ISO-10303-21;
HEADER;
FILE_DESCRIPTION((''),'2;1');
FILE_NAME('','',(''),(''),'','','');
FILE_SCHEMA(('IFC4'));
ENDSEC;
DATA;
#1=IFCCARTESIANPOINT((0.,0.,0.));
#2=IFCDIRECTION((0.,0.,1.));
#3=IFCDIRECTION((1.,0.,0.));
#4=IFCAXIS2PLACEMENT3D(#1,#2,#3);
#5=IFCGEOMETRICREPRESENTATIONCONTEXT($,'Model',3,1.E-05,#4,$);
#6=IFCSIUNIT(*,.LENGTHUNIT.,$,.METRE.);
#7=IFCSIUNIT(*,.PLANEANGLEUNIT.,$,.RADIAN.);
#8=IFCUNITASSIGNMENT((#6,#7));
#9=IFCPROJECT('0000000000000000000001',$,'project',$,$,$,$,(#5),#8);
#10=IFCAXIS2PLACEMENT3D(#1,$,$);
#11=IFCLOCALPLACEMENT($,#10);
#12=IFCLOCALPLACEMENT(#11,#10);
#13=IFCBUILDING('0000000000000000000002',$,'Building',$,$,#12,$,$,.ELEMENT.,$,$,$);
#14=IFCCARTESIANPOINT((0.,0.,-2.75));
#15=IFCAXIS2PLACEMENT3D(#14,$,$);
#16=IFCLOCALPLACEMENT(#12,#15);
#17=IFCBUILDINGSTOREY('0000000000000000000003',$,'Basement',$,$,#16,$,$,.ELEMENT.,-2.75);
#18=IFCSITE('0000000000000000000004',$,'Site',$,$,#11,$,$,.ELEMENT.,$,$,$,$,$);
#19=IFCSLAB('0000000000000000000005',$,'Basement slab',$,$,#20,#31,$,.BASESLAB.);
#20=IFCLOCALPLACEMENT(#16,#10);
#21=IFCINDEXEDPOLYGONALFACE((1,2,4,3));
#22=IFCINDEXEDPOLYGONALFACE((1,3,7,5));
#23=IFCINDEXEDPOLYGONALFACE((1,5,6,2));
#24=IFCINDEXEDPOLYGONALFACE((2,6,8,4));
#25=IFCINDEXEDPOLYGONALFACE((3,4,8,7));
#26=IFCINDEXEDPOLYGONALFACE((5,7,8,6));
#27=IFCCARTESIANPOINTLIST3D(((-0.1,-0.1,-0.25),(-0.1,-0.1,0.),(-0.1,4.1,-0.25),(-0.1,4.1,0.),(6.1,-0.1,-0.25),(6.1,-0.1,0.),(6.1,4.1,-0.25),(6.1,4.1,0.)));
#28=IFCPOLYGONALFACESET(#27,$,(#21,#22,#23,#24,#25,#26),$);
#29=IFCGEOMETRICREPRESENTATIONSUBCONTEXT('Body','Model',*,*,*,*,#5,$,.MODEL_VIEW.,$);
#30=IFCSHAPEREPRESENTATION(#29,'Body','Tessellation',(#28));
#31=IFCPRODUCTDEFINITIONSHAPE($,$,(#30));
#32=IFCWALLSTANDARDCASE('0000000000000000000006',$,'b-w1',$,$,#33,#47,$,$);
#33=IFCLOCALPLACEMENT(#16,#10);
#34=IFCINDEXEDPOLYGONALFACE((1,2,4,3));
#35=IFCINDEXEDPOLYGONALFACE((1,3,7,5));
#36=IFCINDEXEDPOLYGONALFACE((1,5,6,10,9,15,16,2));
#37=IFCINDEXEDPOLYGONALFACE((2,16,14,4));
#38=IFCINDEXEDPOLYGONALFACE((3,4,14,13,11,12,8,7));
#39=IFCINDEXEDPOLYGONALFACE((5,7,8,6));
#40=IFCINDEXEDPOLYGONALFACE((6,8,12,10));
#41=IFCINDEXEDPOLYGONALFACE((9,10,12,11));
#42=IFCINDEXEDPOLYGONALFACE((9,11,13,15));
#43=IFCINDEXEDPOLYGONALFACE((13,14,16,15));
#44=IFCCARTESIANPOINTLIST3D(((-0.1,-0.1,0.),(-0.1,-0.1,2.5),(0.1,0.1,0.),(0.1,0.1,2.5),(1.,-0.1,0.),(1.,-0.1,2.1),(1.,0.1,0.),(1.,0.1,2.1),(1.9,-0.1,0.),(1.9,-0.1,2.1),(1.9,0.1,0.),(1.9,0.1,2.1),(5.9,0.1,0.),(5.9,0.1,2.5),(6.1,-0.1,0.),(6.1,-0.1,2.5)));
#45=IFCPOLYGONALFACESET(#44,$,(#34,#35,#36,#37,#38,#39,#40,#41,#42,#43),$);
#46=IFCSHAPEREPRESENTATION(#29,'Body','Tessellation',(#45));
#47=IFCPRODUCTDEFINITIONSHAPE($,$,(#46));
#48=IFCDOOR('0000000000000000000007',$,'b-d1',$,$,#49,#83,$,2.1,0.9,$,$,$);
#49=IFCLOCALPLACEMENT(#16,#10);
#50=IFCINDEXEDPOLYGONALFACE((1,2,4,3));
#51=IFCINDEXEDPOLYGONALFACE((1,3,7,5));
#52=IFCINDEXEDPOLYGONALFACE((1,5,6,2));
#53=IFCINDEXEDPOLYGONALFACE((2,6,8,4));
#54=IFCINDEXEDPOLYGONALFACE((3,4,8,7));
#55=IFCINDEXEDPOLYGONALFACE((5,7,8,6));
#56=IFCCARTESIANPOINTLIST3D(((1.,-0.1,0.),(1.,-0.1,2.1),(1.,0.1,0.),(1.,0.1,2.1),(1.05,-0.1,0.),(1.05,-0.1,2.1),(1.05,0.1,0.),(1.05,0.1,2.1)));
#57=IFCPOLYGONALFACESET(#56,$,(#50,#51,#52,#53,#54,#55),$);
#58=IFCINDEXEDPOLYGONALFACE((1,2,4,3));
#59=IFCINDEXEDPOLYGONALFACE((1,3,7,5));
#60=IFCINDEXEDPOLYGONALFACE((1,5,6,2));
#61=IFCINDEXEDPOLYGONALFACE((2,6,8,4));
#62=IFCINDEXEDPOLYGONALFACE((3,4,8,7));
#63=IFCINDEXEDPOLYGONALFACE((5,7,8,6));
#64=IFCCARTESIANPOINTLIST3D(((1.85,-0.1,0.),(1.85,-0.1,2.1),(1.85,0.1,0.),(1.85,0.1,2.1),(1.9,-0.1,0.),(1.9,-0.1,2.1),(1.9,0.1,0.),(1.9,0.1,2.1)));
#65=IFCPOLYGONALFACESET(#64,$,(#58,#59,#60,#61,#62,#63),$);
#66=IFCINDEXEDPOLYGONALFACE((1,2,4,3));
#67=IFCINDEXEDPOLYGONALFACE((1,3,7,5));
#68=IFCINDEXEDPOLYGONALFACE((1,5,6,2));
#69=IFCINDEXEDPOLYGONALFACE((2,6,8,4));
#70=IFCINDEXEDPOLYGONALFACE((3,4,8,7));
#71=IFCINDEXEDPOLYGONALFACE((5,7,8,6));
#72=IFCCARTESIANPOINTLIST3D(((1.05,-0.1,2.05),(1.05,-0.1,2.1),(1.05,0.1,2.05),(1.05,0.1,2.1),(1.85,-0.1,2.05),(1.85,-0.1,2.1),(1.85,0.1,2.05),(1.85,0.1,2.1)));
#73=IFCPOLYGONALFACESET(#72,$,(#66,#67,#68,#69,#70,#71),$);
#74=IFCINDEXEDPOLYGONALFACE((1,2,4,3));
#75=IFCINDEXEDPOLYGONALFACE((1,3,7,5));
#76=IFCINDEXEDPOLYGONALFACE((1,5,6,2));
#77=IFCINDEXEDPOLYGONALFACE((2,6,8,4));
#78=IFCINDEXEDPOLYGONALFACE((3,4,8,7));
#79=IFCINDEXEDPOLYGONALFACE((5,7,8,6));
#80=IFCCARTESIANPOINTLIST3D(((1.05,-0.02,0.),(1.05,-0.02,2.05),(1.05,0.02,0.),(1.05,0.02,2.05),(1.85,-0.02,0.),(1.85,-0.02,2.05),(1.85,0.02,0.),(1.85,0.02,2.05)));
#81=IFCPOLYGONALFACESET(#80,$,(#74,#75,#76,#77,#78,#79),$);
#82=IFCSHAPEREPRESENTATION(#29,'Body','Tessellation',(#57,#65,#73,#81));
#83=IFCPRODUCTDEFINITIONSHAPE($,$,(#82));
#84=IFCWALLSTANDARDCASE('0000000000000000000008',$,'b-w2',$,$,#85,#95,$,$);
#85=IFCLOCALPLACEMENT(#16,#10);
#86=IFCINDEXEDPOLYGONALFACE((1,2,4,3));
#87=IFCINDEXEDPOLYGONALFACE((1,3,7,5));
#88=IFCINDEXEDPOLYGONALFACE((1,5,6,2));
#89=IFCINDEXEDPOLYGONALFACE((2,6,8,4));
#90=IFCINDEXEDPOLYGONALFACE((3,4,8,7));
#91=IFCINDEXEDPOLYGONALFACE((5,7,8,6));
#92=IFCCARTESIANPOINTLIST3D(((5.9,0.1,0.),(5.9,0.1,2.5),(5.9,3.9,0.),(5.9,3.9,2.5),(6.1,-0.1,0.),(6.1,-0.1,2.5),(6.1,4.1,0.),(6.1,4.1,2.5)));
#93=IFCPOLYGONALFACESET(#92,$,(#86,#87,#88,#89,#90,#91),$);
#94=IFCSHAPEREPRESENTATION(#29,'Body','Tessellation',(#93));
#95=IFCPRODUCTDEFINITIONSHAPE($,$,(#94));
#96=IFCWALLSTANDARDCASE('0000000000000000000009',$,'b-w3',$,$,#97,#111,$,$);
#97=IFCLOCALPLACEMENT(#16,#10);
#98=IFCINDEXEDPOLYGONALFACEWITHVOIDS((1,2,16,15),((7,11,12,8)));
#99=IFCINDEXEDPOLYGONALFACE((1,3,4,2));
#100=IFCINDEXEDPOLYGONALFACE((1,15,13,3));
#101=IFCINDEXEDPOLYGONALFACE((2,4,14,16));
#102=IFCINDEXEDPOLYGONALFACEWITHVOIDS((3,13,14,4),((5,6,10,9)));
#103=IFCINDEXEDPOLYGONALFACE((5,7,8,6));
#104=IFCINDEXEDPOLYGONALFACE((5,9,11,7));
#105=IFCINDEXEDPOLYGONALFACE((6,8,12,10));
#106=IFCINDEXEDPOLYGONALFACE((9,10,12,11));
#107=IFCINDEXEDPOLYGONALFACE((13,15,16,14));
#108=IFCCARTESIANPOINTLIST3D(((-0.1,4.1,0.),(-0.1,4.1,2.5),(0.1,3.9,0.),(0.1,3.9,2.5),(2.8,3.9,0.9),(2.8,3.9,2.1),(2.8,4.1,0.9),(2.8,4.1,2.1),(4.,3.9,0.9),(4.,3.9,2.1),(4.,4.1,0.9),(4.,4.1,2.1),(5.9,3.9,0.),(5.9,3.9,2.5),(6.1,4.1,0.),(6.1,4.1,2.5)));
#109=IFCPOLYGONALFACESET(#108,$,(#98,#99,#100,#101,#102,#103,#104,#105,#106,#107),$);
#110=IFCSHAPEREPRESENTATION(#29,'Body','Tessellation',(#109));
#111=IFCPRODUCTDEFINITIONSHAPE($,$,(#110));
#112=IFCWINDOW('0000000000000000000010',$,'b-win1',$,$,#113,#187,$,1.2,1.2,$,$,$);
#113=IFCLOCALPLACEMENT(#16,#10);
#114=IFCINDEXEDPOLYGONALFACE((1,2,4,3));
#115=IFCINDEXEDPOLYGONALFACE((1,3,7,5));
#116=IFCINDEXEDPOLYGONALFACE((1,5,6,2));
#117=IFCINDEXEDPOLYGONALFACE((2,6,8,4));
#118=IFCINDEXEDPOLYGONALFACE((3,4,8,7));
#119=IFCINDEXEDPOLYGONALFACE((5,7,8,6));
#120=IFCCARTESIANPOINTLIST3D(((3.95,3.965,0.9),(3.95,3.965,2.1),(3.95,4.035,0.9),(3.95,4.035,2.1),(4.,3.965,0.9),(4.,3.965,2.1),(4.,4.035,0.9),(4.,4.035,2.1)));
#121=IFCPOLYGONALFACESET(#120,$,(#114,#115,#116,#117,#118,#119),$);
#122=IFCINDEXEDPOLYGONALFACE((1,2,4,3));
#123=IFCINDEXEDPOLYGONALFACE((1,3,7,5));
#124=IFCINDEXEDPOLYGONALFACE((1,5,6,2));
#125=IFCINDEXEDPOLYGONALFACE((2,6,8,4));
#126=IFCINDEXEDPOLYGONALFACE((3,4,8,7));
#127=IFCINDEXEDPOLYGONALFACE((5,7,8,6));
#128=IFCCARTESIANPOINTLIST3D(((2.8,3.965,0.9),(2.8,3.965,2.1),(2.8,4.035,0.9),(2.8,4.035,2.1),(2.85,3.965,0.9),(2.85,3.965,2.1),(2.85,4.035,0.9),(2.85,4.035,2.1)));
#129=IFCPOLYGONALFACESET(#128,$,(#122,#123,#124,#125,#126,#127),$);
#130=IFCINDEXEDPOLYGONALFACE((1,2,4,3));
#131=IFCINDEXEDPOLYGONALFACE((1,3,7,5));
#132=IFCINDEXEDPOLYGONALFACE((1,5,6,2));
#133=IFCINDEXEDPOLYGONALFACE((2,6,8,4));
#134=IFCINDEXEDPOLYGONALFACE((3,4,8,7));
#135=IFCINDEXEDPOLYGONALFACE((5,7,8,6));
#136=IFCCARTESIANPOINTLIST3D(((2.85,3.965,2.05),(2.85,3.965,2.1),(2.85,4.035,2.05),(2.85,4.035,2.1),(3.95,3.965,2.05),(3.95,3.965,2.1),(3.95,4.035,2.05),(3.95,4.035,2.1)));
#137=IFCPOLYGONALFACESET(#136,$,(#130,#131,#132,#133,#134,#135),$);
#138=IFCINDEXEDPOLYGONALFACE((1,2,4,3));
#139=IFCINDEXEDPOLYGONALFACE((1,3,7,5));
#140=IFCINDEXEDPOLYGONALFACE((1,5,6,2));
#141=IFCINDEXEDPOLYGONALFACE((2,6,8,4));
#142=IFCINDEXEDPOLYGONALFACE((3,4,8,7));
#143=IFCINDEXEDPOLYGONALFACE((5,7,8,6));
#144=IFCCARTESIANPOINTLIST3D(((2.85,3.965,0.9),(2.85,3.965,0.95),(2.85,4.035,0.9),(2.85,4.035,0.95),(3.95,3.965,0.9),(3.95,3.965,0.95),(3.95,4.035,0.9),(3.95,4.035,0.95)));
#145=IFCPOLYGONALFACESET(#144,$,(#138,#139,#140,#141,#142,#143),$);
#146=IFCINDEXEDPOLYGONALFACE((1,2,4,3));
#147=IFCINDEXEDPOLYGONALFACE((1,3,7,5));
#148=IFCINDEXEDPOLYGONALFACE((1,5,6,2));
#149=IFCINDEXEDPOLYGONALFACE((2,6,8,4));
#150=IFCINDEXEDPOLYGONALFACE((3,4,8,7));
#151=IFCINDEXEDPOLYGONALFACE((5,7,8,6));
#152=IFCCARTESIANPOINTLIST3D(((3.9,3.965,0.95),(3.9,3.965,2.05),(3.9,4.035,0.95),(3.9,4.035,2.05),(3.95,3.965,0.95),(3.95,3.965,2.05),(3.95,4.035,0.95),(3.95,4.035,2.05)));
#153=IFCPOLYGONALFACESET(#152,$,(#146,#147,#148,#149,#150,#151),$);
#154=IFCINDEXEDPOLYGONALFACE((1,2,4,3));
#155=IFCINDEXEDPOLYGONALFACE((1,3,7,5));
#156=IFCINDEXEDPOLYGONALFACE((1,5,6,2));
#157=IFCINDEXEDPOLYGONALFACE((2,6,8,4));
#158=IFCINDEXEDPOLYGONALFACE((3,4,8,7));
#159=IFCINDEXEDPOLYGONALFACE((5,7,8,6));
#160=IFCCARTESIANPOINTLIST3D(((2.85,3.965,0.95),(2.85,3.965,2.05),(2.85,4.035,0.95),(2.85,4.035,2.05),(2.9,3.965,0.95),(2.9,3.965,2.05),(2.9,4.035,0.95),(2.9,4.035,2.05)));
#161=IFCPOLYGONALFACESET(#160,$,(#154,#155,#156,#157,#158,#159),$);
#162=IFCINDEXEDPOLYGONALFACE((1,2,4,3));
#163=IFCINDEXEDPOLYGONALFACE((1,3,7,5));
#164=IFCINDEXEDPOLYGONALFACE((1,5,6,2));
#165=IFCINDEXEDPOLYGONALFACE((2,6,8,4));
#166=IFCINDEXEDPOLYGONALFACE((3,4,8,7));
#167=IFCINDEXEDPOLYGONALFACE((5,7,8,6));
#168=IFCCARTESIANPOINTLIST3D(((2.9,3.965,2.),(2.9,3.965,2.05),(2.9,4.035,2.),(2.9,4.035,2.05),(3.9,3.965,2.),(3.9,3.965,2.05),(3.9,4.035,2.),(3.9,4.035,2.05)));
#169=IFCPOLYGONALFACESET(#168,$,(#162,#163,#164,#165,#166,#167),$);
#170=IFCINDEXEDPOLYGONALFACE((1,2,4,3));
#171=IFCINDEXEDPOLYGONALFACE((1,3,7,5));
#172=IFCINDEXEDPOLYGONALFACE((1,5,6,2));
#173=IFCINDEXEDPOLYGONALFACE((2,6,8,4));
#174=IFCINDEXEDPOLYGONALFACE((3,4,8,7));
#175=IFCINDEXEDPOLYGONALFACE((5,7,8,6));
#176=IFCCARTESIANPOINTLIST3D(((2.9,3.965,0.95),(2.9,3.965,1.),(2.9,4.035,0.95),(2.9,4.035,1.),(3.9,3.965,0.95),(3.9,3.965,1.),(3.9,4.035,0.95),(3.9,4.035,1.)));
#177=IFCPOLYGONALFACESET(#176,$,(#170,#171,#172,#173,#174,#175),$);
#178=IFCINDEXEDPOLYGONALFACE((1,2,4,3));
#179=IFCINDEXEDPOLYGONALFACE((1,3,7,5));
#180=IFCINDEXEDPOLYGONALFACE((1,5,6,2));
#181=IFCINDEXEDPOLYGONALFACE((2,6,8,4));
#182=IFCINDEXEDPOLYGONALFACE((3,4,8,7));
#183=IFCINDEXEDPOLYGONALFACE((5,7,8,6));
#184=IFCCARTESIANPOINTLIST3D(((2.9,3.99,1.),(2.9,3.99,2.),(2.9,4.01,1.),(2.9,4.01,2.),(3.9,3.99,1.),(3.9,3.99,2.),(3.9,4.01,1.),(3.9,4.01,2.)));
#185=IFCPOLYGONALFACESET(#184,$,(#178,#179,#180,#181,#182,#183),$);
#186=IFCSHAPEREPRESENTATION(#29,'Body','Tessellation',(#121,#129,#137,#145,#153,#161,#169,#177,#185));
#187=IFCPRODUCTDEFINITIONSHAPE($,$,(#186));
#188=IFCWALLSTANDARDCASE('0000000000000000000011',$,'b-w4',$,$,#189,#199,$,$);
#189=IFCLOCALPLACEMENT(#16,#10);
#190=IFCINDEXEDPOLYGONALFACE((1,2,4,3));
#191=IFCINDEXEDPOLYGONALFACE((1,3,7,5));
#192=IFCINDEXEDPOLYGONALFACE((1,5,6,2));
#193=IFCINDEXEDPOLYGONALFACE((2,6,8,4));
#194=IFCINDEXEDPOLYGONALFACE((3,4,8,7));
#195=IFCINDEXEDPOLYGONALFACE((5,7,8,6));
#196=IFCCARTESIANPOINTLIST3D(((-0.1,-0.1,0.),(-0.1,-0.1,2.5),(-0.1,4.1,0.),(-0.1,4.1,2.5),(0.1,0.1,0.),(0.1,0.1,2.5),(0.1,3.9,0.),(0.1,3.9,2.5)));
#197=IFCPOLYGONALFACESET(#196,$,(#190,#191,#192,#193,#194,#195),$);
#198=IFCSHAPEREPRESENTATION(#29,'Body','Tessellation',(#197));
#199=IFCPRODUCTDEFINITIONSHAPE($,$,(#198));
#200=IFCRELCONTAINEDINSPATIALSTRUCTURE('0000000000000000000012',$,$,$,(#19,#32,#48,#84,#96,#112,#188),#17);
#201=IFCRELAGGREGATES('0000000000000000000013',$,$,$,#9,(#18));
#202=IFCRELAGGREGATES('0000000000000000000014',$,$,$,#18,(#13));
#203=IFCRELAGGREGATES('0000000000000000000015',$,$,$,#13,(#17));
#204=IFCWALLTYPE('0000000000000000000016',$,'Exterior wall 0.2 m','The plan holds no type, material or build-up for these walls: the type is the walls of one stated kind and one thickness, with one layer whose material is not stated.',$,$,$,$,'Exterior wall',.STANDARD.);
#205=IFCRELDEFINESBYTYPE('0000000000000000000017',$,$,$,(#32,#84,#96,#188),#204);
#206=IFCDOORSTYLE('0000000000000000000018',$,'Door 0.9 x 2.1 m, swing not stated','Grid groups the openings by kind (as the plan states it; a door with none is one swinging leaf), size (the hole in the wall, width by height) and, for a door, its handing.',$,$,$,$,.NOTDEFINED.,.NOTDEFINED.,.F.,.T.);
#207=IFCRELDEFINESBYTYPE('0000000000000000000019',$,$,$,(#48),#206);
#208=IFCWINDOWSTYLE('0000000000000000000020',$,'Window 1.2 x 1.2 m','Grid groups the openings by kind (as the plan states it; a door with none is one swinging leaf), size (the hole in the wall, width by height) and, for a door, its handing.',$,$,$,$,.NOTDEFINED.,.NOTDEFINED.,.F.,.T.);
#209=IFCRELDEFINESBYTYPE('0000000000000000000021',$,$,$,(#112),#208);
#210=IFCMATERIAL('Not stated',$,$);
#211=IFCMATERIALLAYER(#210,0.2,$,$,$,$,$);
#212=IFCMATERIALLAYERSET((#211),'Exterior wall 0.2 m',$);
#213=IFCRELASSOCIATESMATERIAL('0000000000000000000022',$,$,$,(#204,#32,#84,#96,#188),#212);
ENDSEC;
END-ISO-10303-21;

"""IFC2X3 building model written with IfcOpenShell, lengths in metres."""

from ifc_helpers import new_model, si_unit, frame, frame_2d, origin, origin_with_axes, place, context, subcontext, project, spatial, polyline, rectangle, outline, extrude, material, layer, layer_set, layer_usage, type_object, element, fill, save


model = new_model("IFC2X3")

# Units and contexts
model_context = context("Model", 3, precision=1e-05, world=origin_with_axes())
body_context = subcontext(model_context, "Body", "Model", "MODEL_VIEW")
ifc_project = project(units=[si_unit("LENGTHUNIT", "METRE"), si_unit("PLANEANGLEUNIT", "RADIAN")], contexts=[model_context])

# Site, building, storey
site_placement = place(None, origin())
site = spatial("IfcSite", under=ifc_project, at=site_placement, Name="Site", CompositionType="ELEMENT")
building_placement = place(site_placement, origin())
building = spatial("IfcBuilding", under=site, at=building_placement, Name="Building", CompositionType="ELEMENT")
storey_placement = place(building_placement, frame((0.0, 0.0, -2.75)))
storey = spatial("IfcBuildingStorey", under=building, at=storey_placement, Name="Basement", CompositionType="ELEMENT", Elevation=-2.75)

# Slab
slab_placement = place(storey_placement, frame((0.0, 0.0, -0.25)))
element("IfcSlab", 1, at=slab_placement, inside=storey, Name="Basement slab", PredefinedType="BASESLAB", context=body_context, shape_type="SweptSolid", body=[
    extrude(outline(polyline([(-0.1, -0.1), (6.1, -0.1), (6.1, 4.1), (-0.1, 4.1), (-0.1, -0.1)])), origin(), (0.0, 0.0, 1.0), 0.25),
])

# Wall, opening, door
ifc_material = material(Name="Not stated")
ifc_layer = layer(ifc_material, 0.2)
ifc_layer_set = layer_set([ifc_layer], Name="Exterior wall 0.2 m")
ifc_layer_usage = layer_usage(ifc_layer_set, "AXIS2", "POSITIVE", -0.1)
wall_type = type_object("IfcWallType", Name="Exterior wall 0.2 m", Description="The plan holds no type, material or build-up for these walls: the type is the walls of one stated kind and one thickness, with one layer whose material is not stated.", ElementType="Exterior wall", PredefinedType="STANDARD", material=ifc_layer_set)
wall_1_placement = place(storey_placement, origin_with_axes())
wall_1 = element("IfcWallStandardCase", 2, at=wall_1_placement, inside=storey, type_object=wall_type, material=ifc_layer_usage, Name="b-w1", context=body_context, shape_type="SweptSolid", body=[
    extrude(outline(polyline([(-0.1, -0.1), (6.1, -0.1), (5.9, 0.1), (0.1, 0.1), (-0.1, -0.1)])), origin(), (0.0, 0.0, 1.0), 2.5),
])
opening_1_placement = place(wall_1_placement, frame((1.0, 0.0, 0.0)))
opening_1 = element("IfcOpeningElement", 3, at=opening_1_placement, cuts=wall_1, context=body_context, shape_type="SweptSolid", body=[
    extrude(rectangle(XDim=0.9, YDim=0.22, at=frame_2d((0.45, 0.0), x_axis=(1.0, 0.0))), origin(), (0.0, 0.0, 1.0), 2.1),
])
door_style = type_object("IfcDoorStyle", Name="Door 0.9 x 2.1 m, swing not stated", Description="Grid groups the openings by kind (as the plan states it; a door with none is one swinging leaf), size (the hole in the wall, width by height) and, for a door, its handing.", ConstructionType="NOTDEFINED", OperationType="NOTDEFINED", ParameterTakesPrecedence=False, Sizeable=True)
door_placement = place(opening_1_placement, origin())
door = element("IfcDoor", 4, at=door_placement, inside=storey, type_object=door_style, Name="b-d1", OverallHeight=2.1, OverallWidth=0.9, context=body_context, shape_type="SweptSolid", body=[
    extrude(rectangle(XDim=0.05, YDim=0.2, at=frame_2d((0.025, 0.0), x_axis=(1.0, 0.0))), origin(), (0.0, 0.0, 1.0), 2.1),
    extrude(rectangle(XDim=0.05, YDim=0.2, at=frame_2d((0.875, 0.0), x_axis=(1.0, 0.0))), origin(), (0.0, 0.0, 1.0), 2.1),
    extrude(rectangle(XDim=0.8, YDim=0.2, at=frame_2d((0.45, 0.0), x_axis=(1.0, 0.0))), frame((0.0, 0.0, 2.05)), (0.0, 0.0, 1.0), 0.05),
    extrude(rectangle(XDim=0.8, YDim=0.04, at=frame_2d((0.45, 0.0), x_axis=(1.0, 0.0))), origin(), (0.0, 0.0, 1.0), 2.05),
])
fill(opening_1, door)

# Wall
wall_2_placement = place(storey_placement, frame((6.0, 0.0, 0.0), z_axis=(0.0, 0.0, 1.0), x_axis=(0.0, 1.0, 0.0)))
element("IfcWallStandardCase", 5, at=wall_2_placement, inside=storey, type_object=wall_type, material=ifc_layer_usage, Name="b-w2", context=body_context, shape_type="SweptSolid", body=[
    extrude(outline(polyline([(-0.1, -0.1), (4.1, -0.1), (3.9, 0.1), (0.1, 0.1), (-0.1, -0.1)])), origin(), (0.0, 0.0, 1.0), 2.5),
])

# Wall, opening, window
wall_3_placement = place(storey_placement, frame((6.0, 4.0, 0.0), z_axis=(0.0, 0.0, 1.0), x_axis=(-1.0, 0.0, 0.0)))
wall_3 = element("IfcWallStandardCase", 6, at=wall_3_placement, inside=storey, type_object=wall_type, material=ifc_layer_usage, Name="b-w3", context=body_context, shape_type="SweptSolid", body=[
    extrude(outline(polyline([(-0.1, -0.1), (6.1, -0.1), (5.9, 0.1), (0.1, 0.1), (-0.1, -0.1)])), origin(), (0.0, 0.0, 1.0), 2.5),
])
opening_2_placement = place(wall_3_placement, frame((2.0, 0.0, 0.9)))
opening_2 = element("IfcOpeningElement", 7, at=opening_2_placement, cuts=wall_3, context=body_context, shape_type="SweptSolid", body=[
    extrude(rectangle(XDim=1.2, YDim=0.22, at=frame_2d((0.6, 0.0), x_axis=(1.0, 0.0))), origin(), (0.0, 0.0, 1.0), 1.2),
])
window_style = type_object("IfcWindowStyle", Name="Window 1.2 x 1.2 m", Description="Grid groups the openings by kind (as the plan states it; a door with none is one swinging leaf), size (the hole in the wall, width by height) and, for a door, its handing.", ConstructionType="NOTDEFINED", OperationType="NOTDEFINED", ParameterTakesPrecedence=False, Sizeable=True)
window_placement = place(opening_2_placement, origin())
window = element("IfcWindow", 8, at=window_placement, inside=storey, type_object=window_style, Name="b-win1", OverallHeight=1.2, OverallWidth=1.2, context=body_context, shape_type="SweptSolid", body=[
    extrude(rectangle(XDim=0.05, YDim=0.07, at=frame_2d((0.025, 0.0), x_axis=(1.0, 0.0))), origin(), (0.0, 0.0, 1.0), 1.2),
    extrude(rectangle(XDim=0.05, YDim=0.07, at=frame_2d((1.175, 0.0), x_axis=(1.0, 0.0))), origin(), (0.0, 0.0, 1.0), 1.2),
    extrude(rectangle(XDim=1.1, YDim=0.07, at=frame_2d((0.6, 0.0), x_axis=(1.0, 0.0))), frame((0.0, 0.0, 1.15)), (0.0, 0.0, 1.0), 0.05),
    extrude(rectangle(XDim=1.1, YDim=0.07, at=frame_2d((0.6, 0.0), x_axis=(1.0, 0.0))), origin(), (0.0, 0.0, 1.0), 0.05),
    extrude(rectangle(XDim=0.05, YDim=0.07, at=frame_2d((0.075, 0.0), x_axis=(1.0, 0.0))), frame((0.0, 0.0, 0.05)), (0.0, 0.0, 1.0), 1.1),
    extrude(rectangle(XDim=0.05, YDim=0.07, at=frame_2d((1.125, 0.0), x_axis=(1.0, 0.0))), frame((0.0, 0.0, 0.05)), (0.0, 0.0, 1.0), 1.1),
    extrude(rectangle(XDim=1.0, YDim=0.07, at=frame_2d((0.6, 0.0), x_axis=(1.0, 0.0))), frame((0.0, 0.0, 1.1)), (0.0, 0.0, 1.0), 0.05),
    extrude(rectangle(XDim=1.0, YDim=0.07, at=frame_2d((0.6, 0.0), x_axis=(1.0, 0.0))), frame((0.0, 0.0, 0.05)), (0.0, 0.0, 1.0), 0.05),
    extrude(rectangle(XDim=1.0, YDim=0.02, at=frame_2d((0.6, 0.0), x_axis=(1.0, 0.0))), frame((0.0, 0.0, 0.1)), (0.0, 0.0, 1.0), 1.0),
])
fill(opening_2, window)

# Wall
wall_4_placement = place(storey_placement, frame((0.0, 4.0, 0.0), z_axis=(0.0, 0.0, 1.0), x_axis=(0.0, -1.0, 0.0)))
element("IfcWallStandardCase", 9, at=wall_4_placement, inside=storey, type_object=wall_type, material=ifc_layer_usage, Name="b-w4", context=body_context, shape_type="SweptSolid", body=[
    extrude(outline(polyline([(-0.1, -0.1), (4.1, -0.1), (3.9, 0.1), (0.1, 0.1), (-0.1, -0.1)])), origin(), (0.0, 0.0, 1.0), 2.5),
])

save(model, "model.ifc")
